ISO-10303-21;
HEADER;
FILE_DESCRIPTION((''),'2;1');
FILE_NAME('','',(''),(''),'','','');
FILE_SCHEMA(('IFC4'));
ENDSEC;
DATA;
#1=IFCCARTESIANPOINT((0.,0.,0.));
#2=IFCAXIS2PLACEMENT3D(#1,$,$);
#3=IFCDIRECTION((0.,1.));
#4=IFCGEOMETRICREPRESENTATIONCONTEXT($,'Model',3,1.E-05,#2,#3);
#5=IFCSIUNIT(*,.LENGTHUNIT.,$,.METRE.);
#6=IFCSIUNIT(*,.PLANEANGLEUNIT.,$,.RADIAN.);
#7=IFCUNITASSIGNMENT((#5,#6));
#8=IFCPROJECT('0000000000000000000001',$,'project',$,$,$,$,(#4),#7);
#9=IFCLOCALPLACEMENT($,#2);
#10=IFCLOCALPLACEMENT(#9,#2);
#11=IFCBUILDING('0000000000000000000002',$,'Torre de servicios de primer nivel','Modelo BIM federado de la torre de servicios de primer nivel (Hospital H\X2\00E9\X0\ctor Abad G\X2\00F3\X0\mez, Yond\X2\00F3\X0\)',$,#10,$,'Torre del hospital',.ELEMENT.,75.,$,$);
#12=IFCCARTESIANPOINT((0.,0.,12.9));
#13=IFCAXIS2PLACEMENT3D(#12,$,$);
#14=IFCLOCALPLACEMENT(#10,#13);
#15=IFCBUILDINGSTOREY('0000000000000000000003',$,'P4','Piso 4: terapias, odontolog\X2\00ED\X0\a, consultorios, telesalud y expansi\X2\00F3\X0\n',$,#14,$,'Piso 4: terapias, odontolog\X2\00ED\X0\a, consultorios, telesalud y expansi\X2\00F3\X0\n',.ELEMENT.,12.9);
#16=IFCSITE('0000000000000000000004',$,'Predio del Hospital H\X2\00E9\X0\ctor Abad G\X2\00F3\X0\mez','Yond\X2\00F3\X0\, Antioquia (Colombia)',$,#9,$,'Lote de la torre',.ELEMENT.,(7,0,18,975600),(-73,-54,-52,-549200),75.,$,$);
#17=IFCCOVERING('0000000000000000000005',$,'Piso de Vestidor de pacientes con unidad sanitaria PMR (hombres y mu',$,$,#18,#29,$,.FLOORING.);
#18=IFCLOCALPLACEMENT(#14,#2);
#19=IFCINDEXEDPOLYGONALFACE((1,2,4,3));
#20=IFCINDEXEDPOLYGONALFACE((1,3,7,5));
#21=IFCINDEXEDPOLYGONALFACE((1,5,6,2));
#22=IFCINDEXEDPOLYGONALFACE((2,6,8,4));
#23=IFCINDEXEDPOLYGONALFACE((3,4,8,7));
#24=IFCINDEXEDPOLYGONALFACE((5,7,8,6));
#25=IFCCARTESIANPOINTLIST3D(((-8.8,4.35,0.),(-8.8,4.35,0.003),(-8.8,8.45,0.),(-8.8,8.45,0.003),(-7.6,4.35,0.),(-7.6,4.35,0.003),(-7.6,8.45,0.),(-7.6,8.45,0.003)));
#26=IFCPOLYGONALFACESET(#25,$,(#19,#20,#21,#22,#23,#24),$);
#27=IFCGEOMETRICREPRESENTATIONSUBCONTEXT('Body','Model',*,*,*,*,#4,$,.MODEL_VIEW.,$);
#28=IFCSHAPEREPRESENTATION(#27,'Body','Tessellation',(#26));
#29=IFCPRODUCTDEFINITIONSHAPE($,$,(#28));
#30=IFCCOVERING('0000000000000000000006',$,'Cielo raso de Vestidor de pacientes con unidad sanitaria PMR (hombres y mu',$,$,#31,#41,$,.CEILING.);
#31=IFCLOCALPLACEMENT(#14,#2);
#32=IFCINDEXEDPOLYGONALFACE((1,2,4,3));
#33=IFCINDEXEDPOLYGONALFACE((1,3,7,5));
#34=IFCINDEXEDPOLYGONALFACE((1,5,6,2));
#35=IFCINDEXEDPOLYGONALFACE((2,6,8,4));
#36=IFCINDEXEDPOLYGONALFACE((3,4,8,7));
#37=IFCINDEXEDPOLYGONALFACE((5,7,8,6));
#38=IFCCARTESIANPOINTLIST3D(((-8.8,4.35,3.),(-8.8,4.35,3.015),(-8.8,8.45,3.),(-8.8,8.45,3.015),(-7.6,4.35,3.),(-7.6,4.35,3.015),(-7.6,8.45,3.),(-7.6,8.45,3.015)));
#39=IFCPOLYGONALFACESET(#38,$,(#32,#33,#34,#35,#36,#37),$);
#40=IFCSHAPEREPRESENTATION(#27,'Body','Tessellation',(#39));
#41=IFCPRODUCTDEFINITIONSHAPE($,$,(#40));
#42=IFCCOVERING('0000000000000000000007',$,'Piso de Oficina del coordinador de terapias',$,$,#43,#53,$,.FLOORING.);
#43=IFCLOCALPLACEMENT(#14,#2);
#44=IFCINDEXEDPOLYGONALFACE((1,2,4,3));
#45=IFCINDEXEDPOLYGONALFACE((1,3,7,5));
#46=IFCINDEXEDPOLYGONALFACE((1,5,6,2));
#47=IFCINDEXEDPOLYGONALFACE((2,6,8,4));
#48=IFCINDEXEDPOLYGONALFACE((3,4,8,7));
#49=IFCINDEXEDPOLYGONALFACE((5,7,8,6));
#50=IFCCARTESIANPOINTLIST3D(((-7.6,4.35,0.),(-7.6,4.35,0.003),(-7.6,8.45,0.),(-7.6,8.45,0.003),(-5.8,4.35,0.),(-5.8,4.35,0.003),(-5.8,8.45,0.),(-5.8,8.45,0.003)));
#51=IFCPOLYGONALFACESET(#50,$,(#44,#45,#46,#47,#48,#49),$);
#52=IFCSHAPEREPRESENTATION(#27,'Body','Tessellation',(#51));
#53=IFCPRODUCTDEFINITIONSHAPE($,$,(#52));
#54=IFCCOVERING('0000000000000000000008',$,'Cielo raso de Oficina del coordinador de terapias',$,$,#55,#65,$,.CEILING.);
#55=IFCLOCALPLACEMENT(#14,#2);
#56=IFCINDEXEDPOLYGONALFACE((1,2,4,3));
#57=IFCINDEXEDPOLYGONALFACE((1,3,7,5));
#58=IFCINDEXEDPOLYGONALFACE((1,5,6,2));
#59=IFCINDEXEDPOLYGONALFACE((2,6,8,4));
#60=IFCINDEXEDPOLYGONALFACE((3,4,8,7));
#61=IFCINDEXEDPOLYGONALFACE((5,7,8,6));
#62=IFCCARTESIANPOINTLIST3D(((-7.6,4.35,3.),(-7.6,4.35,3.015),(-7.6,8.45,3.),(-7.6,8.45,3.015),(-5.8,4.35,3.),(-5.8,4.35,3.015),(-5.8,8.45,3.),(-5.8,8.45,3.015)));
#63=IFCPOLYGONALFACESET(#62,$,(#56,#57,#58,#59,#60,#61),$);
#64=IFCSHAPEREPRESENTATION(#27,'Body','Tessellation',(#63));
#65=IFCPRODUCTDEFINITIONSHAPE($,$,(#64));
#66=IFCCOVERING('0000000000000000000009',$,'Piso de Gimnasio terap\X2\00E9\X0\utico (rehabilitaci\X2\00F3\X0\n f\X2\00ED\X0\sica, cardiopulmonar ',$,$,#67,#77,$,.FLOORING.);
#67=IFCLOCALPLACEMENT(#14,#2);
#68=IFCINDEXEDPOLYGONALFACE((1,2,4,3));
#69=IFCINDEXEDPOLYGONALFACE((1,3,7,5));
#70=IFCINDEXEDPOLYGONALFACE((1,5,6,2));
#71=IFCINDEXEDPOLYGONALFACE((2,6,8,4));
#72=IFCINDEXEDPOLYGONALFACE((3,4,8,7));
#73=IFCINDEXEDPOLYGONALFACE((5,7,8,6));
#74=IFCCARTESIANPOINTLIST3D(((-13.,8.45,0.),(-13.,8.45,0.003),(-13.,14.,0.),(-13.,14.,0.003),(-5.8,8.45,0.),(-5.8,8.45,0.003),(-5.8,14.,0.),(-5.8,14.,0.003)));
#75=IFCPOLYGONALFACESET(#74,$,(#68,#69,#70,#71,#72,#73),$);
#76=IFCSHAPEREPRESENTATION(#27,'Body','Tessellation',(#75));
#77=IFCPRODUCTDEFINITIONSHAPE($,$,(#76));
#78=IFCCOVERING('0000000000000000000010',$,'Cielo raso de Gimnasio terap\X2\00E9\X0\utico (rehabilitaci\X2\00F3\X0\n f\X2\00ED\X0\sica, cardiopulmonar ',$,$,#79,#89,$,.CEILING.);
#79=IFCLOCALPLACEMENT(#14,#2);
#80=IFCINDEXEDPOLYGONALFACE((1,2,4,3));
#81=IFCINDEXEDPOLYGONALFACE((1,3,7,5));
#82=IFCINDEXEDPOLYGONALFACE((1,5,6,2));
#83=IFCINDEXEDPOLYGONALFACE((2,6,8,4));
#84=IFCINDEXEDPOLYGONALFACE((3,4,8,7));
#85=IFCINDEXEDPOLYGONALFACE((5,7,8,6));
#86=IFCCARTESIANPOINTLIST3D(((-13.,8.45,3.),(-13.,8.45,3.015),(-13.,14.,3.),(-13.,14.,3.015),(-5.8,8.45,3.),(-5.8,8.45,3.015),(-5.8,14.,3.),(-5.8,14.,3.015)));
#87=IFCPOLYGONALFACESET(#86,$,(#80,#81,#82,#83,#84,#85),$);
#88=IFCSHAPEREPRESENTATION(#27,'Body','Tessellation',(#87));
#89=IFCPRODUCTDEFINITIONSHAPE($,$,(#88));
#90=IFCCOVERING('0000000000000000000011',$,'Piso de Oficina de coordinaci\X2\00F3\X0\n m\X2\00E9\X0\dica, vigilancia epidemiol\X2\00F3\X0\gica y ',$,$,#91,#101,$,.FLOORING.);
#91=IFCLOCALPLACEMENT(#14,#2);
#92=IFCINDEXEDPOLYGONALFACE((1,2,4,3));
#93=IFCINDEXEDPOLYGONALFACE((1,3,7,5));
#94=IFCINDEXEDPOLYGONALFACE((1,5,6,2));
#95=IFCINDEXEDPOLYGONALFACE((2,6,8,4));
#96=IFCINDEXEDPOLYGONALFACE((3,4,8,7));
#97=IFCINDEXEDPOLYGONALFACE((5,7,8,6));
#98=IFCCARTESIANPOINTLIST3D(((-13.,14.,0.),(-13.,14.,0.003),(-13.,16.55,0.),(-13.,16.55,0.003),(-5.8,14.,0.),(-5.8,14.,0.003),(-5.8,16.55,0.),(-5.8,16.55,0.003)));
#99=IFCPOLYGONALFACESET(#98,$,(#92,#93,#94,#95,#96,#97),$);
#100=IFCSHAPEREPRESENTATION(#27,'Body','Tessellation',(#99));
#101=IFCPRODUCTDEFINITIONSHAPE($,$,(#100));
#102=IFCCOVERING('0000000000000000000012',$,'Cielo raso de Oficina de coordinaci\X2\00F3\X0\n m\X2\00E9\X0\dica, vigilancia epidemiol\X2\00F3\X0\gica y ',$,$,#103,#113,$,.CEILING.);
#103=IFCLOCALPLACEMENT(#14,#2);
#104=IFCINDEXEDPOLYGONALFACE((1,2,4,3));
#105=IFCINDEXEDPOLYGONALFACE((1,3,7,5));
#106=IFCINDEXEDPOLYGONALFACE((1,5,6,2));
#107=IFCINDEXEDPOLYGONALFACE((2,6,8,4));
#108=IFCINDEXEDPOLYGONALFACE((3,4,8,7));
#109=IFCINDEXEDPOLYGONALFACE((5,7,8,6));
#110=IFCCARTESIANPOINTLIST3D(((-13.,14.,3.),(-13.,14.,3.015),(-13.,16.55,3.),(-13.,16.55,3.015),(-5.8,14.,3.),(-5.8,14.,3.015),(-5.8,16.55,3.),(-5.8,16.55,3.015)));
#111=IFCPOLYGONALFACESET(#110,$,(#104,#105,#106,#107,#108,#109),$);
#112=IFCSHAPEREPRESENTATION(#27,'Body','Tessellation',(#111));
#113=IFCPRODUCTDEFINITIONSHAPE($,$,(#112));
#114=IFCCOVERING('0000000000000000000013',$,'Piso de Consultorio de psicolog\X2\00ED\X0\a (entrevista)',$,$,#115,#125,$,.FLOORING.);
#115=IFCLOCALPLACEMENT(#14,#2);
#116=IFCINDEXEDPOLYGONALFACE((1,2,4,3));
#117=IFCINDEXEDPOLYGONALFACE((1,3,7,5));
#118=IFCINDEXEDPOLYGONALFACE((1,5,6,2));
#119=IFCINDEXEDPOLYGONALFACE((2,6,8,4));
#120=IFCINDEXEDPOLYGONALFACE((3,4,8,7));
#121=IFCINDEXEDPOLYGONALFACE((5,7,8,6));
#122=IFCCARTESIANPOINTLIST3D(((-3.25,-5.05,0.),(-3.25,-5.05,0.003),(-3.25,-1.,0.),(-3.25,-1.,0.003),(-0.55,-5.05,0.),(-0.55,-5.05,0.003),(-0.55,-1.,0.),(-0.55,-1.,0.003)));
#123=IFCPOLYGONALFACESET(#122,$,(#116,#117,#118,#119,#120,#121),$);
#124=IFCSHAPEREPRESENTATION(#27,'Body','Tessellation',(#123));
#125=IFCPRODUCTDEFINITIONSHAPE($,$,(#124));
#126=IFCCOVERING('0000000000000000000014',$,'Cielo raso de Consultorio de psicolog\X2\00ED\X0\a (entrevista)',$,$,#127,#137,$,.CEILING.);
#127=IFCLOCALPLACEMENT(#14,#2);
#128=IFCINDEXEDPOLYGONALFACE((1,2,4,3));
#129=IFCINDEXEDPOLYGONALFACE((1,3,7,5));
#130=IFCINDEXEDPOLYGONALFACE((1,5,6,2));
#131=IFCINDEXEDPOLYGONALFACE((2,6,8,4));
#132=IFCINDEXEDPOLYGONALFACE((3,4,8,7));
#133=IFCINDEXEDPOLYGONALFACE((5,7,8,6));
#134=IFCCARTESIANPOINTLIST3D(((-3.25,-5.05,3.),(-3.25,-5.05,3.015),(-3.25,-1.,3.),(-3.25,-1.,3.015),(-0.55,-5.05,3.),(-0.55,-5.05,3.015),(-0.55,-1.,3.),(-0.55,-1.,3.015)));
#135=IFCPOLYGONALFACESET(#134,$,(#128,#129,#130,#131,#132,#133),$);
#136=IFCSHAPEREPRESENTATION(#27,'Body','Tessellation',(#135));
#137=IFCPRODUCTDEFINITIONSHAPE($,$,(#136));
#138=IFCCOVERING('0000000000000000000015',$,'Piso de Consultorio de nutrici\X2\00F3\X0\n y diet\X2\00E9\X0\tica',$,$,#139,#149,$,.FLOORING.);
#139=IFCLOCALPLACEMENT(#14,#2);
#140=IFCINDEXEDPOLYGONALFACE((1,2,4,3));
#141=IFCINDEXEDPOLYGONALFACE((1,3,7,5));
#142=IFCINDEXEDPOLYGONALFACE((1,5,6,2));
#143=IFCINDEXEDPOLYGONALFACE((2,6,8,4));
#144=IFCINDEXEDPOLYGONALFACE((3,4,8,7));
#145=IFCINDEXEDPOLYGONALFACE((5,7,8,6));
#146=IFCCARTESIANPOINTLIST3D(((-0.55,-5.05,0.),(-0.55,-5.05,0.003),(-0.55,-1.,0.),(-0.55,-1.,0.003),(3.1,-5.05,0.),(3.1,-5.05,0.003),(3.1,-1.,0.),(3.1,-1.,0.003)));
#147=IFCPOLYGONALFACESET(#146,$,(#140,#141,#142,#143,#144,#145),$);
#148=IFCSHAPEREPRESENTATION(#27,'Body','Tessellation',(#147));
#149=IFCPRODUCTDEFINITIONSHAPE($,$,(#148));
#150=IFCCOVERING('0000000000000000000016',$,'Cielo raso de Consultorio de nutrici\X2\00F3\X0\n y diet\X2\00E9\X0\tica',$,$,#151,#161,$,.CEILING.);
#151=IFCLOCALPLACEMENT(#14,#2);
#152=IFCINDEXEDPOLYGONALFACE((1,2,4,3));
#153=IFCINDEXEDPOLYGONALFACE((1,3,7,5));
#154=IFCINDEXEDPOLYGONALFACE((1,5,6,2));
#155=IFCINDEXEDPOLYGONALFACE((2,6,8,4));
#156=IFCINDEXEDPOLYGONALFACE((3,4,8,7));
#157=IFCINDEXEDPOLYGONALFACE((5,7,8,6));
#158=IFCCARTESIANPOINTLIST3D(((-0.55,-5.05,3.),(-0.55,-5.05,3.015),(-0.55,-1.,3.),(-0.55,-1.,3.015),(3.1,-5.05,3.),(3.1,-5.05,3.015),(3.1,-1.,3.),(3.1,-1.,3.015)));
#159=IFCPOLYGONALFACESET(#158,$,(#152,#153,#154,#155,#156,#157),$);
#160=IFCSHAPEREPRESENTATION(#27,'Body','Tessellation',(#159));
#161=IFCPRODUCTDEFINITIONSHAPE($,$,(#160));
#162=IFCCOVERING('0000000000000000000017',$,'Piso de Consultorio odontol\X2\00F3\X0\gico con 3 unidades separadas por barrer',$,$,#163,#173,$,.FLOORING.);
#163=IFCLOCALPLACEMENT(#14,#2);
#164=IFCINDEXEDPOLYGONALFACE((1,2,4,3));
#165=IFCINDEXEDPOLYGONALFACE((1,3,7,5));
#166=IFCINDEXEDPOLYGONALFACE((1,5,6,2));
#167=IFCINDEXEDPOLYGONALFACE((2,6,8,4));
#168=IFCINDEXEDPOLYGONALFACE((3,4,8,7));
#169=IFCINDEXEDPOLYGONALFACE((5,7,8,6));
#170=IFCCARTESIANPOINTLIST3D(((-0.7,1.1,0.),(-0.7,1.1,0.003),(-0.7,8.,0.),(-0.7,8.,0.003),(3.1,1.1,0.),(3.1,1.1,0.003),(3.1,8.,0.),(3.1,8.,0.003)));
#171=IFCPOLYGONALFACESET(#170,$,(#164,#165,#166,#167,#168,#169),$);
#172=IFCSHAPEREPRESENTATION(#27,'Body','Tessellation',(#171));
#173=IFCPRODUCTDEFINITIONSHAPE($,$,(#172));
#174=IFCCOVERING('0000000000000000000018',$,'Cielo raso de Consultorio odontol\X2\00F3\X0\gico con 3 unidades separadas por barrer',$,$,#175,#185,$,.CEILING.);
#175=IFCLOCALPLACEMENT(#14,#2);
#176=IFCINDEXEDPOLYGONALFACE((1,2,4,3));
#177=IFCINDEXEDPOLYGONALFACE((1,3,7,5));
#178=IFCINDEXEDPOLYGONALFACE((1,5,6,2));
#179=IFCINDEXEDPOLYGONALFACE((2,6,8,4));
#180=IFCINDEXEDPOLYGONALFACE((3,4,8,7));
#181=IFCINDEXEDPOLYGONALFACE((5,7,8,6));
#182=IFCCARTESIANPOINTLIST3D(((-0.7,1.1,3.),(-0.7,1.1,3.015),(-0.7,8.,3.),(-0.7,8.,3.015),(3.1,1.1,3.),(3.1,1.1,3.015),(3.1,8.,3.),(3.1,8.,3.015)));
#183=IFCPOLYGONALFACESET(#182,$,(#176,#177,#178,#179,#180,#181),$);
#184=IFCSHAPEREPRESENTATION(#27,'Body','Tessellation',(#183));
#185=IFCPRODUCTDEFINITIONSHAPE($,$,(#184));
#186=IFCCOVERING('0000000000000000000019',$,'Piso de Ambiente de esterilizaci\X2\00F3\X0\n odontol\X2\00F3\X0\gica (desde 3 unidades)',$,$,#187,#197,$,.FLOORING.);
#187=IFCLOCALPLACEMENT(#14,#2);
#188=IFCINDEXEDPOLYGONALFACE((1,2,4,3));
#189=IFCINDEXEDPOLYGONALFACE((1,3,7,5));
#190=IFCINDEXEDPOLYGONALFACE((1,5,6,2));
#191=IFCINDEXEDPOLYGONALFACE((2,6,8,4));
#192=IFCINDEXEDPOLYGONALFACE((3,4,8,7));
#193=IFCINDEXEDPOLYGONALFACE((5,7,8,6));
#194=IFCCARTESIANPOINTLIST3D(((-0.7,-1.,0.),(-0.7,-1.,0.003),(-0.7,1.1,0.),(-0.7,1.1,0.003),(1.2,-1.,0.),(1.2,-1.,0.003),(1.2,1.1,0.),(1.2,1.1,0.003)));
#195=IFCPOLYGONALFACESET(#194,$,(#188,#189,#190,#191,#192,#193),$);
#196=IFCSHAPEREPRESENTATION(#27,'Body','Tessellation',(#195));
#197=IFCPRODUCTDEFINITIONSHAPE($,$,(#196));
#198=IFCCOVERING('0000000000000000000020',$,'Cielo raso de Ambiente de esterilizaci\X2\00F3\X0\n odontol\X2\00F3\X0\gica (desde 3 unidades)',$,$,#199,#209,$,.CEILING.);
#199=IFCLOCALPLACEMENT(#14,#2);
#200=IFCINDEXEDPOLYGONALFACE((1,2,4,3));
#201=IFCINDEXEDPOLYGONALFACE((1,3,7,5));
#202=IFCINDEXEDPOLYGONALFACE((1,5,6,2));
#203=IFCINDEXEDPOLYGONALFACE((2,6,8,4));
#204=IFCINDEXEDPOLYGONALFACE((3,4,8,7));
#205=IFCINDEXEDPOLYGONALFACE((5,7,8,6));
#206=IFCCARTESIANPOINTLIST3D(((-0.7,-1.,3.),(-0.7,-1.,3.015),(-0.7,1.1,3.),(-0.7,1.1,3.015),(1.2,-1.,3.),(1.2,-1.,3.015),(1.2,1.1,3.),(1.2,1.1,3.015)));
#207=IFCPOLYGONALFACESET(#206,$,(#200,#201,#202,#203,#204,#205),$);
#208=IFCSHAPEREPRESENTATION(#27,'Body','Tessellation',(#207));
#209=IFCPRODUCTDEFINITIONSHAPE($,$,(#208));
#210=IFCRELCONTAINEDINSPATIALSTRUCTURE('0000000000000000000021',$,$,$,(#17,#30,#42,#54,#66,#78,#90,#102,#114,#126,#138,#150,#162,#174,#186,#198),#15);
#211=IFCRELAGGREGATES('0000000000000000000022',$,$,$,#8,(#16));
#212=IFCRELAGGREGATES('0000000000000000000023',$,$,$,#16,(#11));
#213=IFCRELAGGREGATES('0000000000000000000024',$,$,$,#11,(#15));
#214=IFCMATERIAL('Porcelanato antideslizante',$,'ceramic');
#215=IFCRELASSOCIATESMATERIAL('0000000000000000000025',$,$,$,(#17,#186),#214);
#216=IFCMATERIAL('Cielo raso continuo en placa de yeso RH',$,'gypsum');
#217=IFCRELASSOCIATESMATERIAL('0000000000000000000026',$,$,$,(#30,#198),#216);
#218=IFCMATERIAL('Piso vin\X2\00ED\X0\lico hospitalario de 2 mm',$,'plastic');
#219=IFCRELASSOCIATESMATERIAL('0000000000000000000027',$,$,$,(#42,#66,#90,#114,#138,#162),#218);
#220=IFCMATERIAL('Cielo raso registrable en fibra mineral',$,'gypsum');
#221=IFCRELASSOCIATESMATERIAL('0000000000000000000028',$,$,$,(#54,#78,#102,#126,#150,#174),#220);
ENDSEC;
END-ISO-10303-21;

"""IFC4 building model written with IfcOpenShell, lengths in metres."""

from ifc_helpers import new_model, si_unit, direction, frame, origin, place, context, subcontext, project, spatial, indexed_curve, outline, extrude, material, element, save


model = new_model("IFC4")

# Units and contexts
model_context = context("Model", 3, precision=1e-05, world=origin(), true_north=direction((0.0, 1.0)))
body_context = subcontext(model_context, "Body", "Model", "MODEL_VIEW")
ifc_project = project(units=[si_unit("LENGTHUNIT", "METRE"), si_unit("PLANEANGLEUNIT", "RADIAN")], contexts=[model_context])

# Site, building, storey
site_placement = place(None, origin())
site = spatial("IfcSite", under=ifc_project, at=site_placement, Name="Predio del Hospital Héctor Abad Gómez", Description="Yondó, Antioquia (Colombia)", LongName="Lote de la torre", CompositionType="ELEMENT", RefLatitude=(7, 0, 18, 975600), RefLongitude=(-73, -54, -52, -549200), RefElevation=75.0)
building_placement = place(site_placement, origin())
building = spatial("IfcBuilding", under=site, at=building_placement, Name="Torre de servicios de primer nivel", Description="Modelo BIM federado de la torre de servicios de primer nivel (Hospital Héctor Abad Gómez, Yondó)", LongName="Torre del hospital", CompositionType="ELEMENT", ElevationOfRefHeight=75.0)
placement = place(building_placement, frame((0.0, 0.0, 12.9)))
storey = spatial("IfcBuildingStorey", under=building, at=placement, Name="P4", Description="Piso 4: terapias, odontología, consultorios, telesalud y expansión", LongName="Piso 4: terapias, odontología, consultorios, telesalud y expansión", CompositionType="ELEMENT", Elevation=12.9)

# Coverings
ifc_material_1 = material(Name="Porcelanato antideslizante", Category="ceramic")
element("IfcCovering", 1, at=placement, inside=storey, material=ifc_material_1, Name="Piso de Vestidor de pacientes con unidad sanitaria PMR (hombres y mu", PredefinedType="FLOORING", context=body_context, shape_type="SweptSolid", body=[
    extrude(outline(indexed_curve([(-8.8, 4.35), (-7.6, 4.35), (-7.6, 8.45), (-8.8, 8.45), (-8.8, 4.35)], self_intersect=False)), origin(), (0.0, 0.0, 1.0), 0.003),
])
ifc_material_2 = material(Name="Cielo raso continuo en placa de yeso RH", Category="gypsum")
element("IfcCovering", 2, at=placement, inside=storey, material=ifc_material_2, Name="Cielo raso de Vestidor de pacientes con unidad sanitaria PMR (hombres y mu", PredefinedType="CEILING", context=body_context, shape_type="SweptSolid", body=[
    extrude(outline(indexed_curve([(-8.8, 4.35), (-7.6, 4.35), (-7.6, 8.45), (-8.8, 8.45), (-8.8, 4.35)], self_intersect=False)), frame((0.0, 0.0, 3.0)), (0.0, 0.0, 1.0), 0.015),
])
ifc_material_3 = material(Name="Piso vinílico hospitalario de 2 mm", Category="plastic")
element("IfcCovering", 3, at=placement, inside=storey, material=ifc_material_3, Name="Piso de Oficina del coordinador de terapias", PredefinedType="FLOORING", context=body_context, shape_type="SweptSolid", body=[
    extrude(outline(indexed_curve([(-7.6, 4.35), (-5.8, 4.35), (-5.8, 8.45), (-7.6, 8.45), (-7.6, 4.35)], self_intersect=False)), origin(), (0.0, 0.0, 1.0), 0.003),
])
ifc_material_4 = material(Name="Cielo raso registrable en fibra mineral", Category="gypsum")
element("IfcCovering", 4, at=placement, inside=storey, material=ifc_material_4, Name="Cielo raso de Oficina del coordinador de terapias", PredefinedType="CEILING", context=body_context, shape_type="SweptSolid", body=[
    extrude(outline(indexed_curve([(-7.6, 4.35), (-5.8, 4.35), (-5.8, 8.45), (-7.6, 8.45), (-7.6, 4.35)], self_intersect=False)), frame((0.0, 0.0, 3.0)), (0.0, 0.0, 1.0), 0.015),
])
element("IfcCovering", 5, at=placement, inside=storey, material=ifc_material_3, Name="Piso de Gimnasio terapéutico (rehabilitación física, cardiopulmonar ", PredefinedType="FLOORING", context=body_context, shape_type="SweptSolid", body=[
    extrude(outline(indexed_curve([(-13.0, 8.45), (-5.8, 8.45), (-5.8, 14.0), (-13.0, 14.0), (-13.0, 8.45)], self_intersect=False)), origin(), (0.0, 0.0, 1.0), 0.003),
])
element("IfcCovering", 6, at=placement, inside=storey, material=ifc_material_4, Name="Cielo raso de Gimnasio terapéutico (rehabilitación física, cardiopulmonar ", PredefinedType="CEILING", context=body_context, shape_type="SweptSolid", body=[
    extrude(outline(indexed_curve([(-13.0, 8.45), (-5.8, 8.45), (-5.8, 14.0), (-13.0, 14.0), (-13.0, 8.45)], self_intersect=False)), frame((0.0, 0.0, 3.0)), (0.0, 0.0, 1.0), 0.015),
])
element("IfcCovering", 7, at=placement, inside=storey, material=ifc_material_3, Name="Piso de Oficina de coordinación médica, vigilancia epidemiológica y ", PredefinedType="FLOORING", context=body_context, shape_type="SweptSolid", body=[
    extrude(outline(indexed_curve([(-13.0, 14.0), (-5.8, 14.0), (-5.8, 16.55), (-13.0, 16.55), (-13.0, 14.0)], self_intersect=False)), origin(), (0.0, 0.0, 1.0), 0.003),
])
element("IfcCovering", 8, at=placement, inside=storey, material=ifc_material_4, Name="Cielo raso de Oficina de coordinación médica, vigilancia epidemiológica y ", PredefinedType="CEILING", context=body_context, shape_type="SweptSolid", body=[
    extrude(outline(indexed_curve([(-13.0, 14.0), (-5.8, 14.0), (-5.8, 16.55), (-13.0, 16.55), (-13.0, 14.0)], self_intersect=False)), frame((0.0, 0.0, 3.0)), (0.0, 0.0, 1.0), 0.015),
])
element("IfcCovering", 9, at=placement, inside=storey, material=ifc_material_3, Name="Piso de Consultorio de psicología (entrevista)", PredefinedType="FLOORING", context=body_context, shape_type="SweptSolid", body=[
    extrude(outline(indexed_curve([(-3.25, -5.05), (-0.55, -5.05), (-0.55, -1.0), (-3.25, -1.0), (-3.25, -5.05)], self_intersect=False)), origin(), (0.0, 0.0, 1.0), 0.003),
])
element("IfcCovering", 10, at=placement, inside=storey, material=ifc_material_4, Name="Cielo raso de Consultorio de psicología (entrevista)", PredefinedType="CEILING", context=body_context, shape_type="SweptSolid", body=[
    extrude(outline(indexed_curve([(-3.25, -5.05), (-0.55, -5.05), (-0.55, -1.0), (-3.25, -1.0), (-3.25, -5.05)], self_intersect=False)), frame((0.0, 0.0, 3.0)), (0.0, 0.0, 1.0), 0.015),
])
element("IfcCovering", 11, at=placement, inside=storey, material=ifc_material_3, Name="Piso de Consultorio de nutrición y dietética", PredefinedType="FLOORING", context=body_context, shape_type="SweptSolid", body=[
    extrude(outline(indexed_curve([(-0.55, -5.05), (3.1, -5.05), (3.1, -1.0), (-0.55, -1.0), (-0.55, -5.05)], self_intersect=False)), origin(), (0.0, 0.0, 1.0), 0.003),
])
element("IfcCovering", 12, at=placement, inside=storey, material=ifc_material_4, Name="Cielo raso de Consultorio de nutrición y dietética", PredefinedType="CEILING", context=body_context, shape_type="SweptSolid", body=[
    extrude(outline(indexed_curve([(-0.55, -5.05), (3.1, -5.05), (3.1, -1.0), (-0.55, -1.0), (-0.55, -5.05)], self_intersect=False)), frame((0.0, 0.0, 3.0)), (0.0, 0.0, 1.0), 0.015),
])
element("IfcCovering", 13, at=placement, inside=storey, material=ifc_material_3, Name="Piso de Consultorio odontológico con 3 unidades separadas por barrer", PredefinedType="FLOORING", context=body_context, shape_type="SweptSolid", body=[
    extrude(outline(indexed_curve([(-0.7, 1.1), (3.1, 1.1), (3.1, 8.0), (-0.7, 8.0), (-0.7, 1.1)], self_intersect=False)), origin(), (0.0, 0.0, 1.0), 0.003),
])
element("IfcCovering", 14, at=placement, inside=storey, material=ifc_material_4, Name="Cielo raso de Consultorio odontológico con 3 unidades separadas por barrer", PredefinedType="CEILING", context=body_context, shape_type="SweptSolid", body=[
    extrude(outline(indexed_curve([(-0.7, 1.1), (3.1, 1.1), (3.1, 8.0), (-0.7, 8.0), (-0.7, 1.1)], self_intersect=False)), frame((0.0, 0.0, 3.0)), (0.0, 0.0, 1.0), 0.015),
])
element("IfcCovering", 15, at=placement, inside=storey, material=ifc_material_1, Name="Piso de Ambiente de esterilización odontológica (desde 3 unidades)", PredefinedType="FLOORING", context=body_context, shape_type="SweptSolid", body=[
    extrude(outline(indexed_curve([(-0.7, -1.0), (1.2, -1.0), (1.2, 1.1), (-0.7, 1.1), (-0.7, -1.0)], self_intersect=False)), origin(), (0.0, 0.0, 1.0), 0.003),
])
element("IfcCovering", 16, at=placement, inside=storey, material=ifc_material_2, Name="Cielo raso de Ambiente de esterilización odontológica (desde 3 unidades)", PredefinedType="CEILING", context=body_context, shape_type="SweptSolid", body=[
    extrude(outline(indexed_curve([(-0.7, -1.0), (1.2, -1.0), (1.2, 1.1), (-0.7, 1.1), (-0.7, -1.0)], self_intersect=False)), frame((0.0, 0.0, 3.0)), (0.0, 0.0, 1.0), 0.015),
])

save(model, "model.ifc")
